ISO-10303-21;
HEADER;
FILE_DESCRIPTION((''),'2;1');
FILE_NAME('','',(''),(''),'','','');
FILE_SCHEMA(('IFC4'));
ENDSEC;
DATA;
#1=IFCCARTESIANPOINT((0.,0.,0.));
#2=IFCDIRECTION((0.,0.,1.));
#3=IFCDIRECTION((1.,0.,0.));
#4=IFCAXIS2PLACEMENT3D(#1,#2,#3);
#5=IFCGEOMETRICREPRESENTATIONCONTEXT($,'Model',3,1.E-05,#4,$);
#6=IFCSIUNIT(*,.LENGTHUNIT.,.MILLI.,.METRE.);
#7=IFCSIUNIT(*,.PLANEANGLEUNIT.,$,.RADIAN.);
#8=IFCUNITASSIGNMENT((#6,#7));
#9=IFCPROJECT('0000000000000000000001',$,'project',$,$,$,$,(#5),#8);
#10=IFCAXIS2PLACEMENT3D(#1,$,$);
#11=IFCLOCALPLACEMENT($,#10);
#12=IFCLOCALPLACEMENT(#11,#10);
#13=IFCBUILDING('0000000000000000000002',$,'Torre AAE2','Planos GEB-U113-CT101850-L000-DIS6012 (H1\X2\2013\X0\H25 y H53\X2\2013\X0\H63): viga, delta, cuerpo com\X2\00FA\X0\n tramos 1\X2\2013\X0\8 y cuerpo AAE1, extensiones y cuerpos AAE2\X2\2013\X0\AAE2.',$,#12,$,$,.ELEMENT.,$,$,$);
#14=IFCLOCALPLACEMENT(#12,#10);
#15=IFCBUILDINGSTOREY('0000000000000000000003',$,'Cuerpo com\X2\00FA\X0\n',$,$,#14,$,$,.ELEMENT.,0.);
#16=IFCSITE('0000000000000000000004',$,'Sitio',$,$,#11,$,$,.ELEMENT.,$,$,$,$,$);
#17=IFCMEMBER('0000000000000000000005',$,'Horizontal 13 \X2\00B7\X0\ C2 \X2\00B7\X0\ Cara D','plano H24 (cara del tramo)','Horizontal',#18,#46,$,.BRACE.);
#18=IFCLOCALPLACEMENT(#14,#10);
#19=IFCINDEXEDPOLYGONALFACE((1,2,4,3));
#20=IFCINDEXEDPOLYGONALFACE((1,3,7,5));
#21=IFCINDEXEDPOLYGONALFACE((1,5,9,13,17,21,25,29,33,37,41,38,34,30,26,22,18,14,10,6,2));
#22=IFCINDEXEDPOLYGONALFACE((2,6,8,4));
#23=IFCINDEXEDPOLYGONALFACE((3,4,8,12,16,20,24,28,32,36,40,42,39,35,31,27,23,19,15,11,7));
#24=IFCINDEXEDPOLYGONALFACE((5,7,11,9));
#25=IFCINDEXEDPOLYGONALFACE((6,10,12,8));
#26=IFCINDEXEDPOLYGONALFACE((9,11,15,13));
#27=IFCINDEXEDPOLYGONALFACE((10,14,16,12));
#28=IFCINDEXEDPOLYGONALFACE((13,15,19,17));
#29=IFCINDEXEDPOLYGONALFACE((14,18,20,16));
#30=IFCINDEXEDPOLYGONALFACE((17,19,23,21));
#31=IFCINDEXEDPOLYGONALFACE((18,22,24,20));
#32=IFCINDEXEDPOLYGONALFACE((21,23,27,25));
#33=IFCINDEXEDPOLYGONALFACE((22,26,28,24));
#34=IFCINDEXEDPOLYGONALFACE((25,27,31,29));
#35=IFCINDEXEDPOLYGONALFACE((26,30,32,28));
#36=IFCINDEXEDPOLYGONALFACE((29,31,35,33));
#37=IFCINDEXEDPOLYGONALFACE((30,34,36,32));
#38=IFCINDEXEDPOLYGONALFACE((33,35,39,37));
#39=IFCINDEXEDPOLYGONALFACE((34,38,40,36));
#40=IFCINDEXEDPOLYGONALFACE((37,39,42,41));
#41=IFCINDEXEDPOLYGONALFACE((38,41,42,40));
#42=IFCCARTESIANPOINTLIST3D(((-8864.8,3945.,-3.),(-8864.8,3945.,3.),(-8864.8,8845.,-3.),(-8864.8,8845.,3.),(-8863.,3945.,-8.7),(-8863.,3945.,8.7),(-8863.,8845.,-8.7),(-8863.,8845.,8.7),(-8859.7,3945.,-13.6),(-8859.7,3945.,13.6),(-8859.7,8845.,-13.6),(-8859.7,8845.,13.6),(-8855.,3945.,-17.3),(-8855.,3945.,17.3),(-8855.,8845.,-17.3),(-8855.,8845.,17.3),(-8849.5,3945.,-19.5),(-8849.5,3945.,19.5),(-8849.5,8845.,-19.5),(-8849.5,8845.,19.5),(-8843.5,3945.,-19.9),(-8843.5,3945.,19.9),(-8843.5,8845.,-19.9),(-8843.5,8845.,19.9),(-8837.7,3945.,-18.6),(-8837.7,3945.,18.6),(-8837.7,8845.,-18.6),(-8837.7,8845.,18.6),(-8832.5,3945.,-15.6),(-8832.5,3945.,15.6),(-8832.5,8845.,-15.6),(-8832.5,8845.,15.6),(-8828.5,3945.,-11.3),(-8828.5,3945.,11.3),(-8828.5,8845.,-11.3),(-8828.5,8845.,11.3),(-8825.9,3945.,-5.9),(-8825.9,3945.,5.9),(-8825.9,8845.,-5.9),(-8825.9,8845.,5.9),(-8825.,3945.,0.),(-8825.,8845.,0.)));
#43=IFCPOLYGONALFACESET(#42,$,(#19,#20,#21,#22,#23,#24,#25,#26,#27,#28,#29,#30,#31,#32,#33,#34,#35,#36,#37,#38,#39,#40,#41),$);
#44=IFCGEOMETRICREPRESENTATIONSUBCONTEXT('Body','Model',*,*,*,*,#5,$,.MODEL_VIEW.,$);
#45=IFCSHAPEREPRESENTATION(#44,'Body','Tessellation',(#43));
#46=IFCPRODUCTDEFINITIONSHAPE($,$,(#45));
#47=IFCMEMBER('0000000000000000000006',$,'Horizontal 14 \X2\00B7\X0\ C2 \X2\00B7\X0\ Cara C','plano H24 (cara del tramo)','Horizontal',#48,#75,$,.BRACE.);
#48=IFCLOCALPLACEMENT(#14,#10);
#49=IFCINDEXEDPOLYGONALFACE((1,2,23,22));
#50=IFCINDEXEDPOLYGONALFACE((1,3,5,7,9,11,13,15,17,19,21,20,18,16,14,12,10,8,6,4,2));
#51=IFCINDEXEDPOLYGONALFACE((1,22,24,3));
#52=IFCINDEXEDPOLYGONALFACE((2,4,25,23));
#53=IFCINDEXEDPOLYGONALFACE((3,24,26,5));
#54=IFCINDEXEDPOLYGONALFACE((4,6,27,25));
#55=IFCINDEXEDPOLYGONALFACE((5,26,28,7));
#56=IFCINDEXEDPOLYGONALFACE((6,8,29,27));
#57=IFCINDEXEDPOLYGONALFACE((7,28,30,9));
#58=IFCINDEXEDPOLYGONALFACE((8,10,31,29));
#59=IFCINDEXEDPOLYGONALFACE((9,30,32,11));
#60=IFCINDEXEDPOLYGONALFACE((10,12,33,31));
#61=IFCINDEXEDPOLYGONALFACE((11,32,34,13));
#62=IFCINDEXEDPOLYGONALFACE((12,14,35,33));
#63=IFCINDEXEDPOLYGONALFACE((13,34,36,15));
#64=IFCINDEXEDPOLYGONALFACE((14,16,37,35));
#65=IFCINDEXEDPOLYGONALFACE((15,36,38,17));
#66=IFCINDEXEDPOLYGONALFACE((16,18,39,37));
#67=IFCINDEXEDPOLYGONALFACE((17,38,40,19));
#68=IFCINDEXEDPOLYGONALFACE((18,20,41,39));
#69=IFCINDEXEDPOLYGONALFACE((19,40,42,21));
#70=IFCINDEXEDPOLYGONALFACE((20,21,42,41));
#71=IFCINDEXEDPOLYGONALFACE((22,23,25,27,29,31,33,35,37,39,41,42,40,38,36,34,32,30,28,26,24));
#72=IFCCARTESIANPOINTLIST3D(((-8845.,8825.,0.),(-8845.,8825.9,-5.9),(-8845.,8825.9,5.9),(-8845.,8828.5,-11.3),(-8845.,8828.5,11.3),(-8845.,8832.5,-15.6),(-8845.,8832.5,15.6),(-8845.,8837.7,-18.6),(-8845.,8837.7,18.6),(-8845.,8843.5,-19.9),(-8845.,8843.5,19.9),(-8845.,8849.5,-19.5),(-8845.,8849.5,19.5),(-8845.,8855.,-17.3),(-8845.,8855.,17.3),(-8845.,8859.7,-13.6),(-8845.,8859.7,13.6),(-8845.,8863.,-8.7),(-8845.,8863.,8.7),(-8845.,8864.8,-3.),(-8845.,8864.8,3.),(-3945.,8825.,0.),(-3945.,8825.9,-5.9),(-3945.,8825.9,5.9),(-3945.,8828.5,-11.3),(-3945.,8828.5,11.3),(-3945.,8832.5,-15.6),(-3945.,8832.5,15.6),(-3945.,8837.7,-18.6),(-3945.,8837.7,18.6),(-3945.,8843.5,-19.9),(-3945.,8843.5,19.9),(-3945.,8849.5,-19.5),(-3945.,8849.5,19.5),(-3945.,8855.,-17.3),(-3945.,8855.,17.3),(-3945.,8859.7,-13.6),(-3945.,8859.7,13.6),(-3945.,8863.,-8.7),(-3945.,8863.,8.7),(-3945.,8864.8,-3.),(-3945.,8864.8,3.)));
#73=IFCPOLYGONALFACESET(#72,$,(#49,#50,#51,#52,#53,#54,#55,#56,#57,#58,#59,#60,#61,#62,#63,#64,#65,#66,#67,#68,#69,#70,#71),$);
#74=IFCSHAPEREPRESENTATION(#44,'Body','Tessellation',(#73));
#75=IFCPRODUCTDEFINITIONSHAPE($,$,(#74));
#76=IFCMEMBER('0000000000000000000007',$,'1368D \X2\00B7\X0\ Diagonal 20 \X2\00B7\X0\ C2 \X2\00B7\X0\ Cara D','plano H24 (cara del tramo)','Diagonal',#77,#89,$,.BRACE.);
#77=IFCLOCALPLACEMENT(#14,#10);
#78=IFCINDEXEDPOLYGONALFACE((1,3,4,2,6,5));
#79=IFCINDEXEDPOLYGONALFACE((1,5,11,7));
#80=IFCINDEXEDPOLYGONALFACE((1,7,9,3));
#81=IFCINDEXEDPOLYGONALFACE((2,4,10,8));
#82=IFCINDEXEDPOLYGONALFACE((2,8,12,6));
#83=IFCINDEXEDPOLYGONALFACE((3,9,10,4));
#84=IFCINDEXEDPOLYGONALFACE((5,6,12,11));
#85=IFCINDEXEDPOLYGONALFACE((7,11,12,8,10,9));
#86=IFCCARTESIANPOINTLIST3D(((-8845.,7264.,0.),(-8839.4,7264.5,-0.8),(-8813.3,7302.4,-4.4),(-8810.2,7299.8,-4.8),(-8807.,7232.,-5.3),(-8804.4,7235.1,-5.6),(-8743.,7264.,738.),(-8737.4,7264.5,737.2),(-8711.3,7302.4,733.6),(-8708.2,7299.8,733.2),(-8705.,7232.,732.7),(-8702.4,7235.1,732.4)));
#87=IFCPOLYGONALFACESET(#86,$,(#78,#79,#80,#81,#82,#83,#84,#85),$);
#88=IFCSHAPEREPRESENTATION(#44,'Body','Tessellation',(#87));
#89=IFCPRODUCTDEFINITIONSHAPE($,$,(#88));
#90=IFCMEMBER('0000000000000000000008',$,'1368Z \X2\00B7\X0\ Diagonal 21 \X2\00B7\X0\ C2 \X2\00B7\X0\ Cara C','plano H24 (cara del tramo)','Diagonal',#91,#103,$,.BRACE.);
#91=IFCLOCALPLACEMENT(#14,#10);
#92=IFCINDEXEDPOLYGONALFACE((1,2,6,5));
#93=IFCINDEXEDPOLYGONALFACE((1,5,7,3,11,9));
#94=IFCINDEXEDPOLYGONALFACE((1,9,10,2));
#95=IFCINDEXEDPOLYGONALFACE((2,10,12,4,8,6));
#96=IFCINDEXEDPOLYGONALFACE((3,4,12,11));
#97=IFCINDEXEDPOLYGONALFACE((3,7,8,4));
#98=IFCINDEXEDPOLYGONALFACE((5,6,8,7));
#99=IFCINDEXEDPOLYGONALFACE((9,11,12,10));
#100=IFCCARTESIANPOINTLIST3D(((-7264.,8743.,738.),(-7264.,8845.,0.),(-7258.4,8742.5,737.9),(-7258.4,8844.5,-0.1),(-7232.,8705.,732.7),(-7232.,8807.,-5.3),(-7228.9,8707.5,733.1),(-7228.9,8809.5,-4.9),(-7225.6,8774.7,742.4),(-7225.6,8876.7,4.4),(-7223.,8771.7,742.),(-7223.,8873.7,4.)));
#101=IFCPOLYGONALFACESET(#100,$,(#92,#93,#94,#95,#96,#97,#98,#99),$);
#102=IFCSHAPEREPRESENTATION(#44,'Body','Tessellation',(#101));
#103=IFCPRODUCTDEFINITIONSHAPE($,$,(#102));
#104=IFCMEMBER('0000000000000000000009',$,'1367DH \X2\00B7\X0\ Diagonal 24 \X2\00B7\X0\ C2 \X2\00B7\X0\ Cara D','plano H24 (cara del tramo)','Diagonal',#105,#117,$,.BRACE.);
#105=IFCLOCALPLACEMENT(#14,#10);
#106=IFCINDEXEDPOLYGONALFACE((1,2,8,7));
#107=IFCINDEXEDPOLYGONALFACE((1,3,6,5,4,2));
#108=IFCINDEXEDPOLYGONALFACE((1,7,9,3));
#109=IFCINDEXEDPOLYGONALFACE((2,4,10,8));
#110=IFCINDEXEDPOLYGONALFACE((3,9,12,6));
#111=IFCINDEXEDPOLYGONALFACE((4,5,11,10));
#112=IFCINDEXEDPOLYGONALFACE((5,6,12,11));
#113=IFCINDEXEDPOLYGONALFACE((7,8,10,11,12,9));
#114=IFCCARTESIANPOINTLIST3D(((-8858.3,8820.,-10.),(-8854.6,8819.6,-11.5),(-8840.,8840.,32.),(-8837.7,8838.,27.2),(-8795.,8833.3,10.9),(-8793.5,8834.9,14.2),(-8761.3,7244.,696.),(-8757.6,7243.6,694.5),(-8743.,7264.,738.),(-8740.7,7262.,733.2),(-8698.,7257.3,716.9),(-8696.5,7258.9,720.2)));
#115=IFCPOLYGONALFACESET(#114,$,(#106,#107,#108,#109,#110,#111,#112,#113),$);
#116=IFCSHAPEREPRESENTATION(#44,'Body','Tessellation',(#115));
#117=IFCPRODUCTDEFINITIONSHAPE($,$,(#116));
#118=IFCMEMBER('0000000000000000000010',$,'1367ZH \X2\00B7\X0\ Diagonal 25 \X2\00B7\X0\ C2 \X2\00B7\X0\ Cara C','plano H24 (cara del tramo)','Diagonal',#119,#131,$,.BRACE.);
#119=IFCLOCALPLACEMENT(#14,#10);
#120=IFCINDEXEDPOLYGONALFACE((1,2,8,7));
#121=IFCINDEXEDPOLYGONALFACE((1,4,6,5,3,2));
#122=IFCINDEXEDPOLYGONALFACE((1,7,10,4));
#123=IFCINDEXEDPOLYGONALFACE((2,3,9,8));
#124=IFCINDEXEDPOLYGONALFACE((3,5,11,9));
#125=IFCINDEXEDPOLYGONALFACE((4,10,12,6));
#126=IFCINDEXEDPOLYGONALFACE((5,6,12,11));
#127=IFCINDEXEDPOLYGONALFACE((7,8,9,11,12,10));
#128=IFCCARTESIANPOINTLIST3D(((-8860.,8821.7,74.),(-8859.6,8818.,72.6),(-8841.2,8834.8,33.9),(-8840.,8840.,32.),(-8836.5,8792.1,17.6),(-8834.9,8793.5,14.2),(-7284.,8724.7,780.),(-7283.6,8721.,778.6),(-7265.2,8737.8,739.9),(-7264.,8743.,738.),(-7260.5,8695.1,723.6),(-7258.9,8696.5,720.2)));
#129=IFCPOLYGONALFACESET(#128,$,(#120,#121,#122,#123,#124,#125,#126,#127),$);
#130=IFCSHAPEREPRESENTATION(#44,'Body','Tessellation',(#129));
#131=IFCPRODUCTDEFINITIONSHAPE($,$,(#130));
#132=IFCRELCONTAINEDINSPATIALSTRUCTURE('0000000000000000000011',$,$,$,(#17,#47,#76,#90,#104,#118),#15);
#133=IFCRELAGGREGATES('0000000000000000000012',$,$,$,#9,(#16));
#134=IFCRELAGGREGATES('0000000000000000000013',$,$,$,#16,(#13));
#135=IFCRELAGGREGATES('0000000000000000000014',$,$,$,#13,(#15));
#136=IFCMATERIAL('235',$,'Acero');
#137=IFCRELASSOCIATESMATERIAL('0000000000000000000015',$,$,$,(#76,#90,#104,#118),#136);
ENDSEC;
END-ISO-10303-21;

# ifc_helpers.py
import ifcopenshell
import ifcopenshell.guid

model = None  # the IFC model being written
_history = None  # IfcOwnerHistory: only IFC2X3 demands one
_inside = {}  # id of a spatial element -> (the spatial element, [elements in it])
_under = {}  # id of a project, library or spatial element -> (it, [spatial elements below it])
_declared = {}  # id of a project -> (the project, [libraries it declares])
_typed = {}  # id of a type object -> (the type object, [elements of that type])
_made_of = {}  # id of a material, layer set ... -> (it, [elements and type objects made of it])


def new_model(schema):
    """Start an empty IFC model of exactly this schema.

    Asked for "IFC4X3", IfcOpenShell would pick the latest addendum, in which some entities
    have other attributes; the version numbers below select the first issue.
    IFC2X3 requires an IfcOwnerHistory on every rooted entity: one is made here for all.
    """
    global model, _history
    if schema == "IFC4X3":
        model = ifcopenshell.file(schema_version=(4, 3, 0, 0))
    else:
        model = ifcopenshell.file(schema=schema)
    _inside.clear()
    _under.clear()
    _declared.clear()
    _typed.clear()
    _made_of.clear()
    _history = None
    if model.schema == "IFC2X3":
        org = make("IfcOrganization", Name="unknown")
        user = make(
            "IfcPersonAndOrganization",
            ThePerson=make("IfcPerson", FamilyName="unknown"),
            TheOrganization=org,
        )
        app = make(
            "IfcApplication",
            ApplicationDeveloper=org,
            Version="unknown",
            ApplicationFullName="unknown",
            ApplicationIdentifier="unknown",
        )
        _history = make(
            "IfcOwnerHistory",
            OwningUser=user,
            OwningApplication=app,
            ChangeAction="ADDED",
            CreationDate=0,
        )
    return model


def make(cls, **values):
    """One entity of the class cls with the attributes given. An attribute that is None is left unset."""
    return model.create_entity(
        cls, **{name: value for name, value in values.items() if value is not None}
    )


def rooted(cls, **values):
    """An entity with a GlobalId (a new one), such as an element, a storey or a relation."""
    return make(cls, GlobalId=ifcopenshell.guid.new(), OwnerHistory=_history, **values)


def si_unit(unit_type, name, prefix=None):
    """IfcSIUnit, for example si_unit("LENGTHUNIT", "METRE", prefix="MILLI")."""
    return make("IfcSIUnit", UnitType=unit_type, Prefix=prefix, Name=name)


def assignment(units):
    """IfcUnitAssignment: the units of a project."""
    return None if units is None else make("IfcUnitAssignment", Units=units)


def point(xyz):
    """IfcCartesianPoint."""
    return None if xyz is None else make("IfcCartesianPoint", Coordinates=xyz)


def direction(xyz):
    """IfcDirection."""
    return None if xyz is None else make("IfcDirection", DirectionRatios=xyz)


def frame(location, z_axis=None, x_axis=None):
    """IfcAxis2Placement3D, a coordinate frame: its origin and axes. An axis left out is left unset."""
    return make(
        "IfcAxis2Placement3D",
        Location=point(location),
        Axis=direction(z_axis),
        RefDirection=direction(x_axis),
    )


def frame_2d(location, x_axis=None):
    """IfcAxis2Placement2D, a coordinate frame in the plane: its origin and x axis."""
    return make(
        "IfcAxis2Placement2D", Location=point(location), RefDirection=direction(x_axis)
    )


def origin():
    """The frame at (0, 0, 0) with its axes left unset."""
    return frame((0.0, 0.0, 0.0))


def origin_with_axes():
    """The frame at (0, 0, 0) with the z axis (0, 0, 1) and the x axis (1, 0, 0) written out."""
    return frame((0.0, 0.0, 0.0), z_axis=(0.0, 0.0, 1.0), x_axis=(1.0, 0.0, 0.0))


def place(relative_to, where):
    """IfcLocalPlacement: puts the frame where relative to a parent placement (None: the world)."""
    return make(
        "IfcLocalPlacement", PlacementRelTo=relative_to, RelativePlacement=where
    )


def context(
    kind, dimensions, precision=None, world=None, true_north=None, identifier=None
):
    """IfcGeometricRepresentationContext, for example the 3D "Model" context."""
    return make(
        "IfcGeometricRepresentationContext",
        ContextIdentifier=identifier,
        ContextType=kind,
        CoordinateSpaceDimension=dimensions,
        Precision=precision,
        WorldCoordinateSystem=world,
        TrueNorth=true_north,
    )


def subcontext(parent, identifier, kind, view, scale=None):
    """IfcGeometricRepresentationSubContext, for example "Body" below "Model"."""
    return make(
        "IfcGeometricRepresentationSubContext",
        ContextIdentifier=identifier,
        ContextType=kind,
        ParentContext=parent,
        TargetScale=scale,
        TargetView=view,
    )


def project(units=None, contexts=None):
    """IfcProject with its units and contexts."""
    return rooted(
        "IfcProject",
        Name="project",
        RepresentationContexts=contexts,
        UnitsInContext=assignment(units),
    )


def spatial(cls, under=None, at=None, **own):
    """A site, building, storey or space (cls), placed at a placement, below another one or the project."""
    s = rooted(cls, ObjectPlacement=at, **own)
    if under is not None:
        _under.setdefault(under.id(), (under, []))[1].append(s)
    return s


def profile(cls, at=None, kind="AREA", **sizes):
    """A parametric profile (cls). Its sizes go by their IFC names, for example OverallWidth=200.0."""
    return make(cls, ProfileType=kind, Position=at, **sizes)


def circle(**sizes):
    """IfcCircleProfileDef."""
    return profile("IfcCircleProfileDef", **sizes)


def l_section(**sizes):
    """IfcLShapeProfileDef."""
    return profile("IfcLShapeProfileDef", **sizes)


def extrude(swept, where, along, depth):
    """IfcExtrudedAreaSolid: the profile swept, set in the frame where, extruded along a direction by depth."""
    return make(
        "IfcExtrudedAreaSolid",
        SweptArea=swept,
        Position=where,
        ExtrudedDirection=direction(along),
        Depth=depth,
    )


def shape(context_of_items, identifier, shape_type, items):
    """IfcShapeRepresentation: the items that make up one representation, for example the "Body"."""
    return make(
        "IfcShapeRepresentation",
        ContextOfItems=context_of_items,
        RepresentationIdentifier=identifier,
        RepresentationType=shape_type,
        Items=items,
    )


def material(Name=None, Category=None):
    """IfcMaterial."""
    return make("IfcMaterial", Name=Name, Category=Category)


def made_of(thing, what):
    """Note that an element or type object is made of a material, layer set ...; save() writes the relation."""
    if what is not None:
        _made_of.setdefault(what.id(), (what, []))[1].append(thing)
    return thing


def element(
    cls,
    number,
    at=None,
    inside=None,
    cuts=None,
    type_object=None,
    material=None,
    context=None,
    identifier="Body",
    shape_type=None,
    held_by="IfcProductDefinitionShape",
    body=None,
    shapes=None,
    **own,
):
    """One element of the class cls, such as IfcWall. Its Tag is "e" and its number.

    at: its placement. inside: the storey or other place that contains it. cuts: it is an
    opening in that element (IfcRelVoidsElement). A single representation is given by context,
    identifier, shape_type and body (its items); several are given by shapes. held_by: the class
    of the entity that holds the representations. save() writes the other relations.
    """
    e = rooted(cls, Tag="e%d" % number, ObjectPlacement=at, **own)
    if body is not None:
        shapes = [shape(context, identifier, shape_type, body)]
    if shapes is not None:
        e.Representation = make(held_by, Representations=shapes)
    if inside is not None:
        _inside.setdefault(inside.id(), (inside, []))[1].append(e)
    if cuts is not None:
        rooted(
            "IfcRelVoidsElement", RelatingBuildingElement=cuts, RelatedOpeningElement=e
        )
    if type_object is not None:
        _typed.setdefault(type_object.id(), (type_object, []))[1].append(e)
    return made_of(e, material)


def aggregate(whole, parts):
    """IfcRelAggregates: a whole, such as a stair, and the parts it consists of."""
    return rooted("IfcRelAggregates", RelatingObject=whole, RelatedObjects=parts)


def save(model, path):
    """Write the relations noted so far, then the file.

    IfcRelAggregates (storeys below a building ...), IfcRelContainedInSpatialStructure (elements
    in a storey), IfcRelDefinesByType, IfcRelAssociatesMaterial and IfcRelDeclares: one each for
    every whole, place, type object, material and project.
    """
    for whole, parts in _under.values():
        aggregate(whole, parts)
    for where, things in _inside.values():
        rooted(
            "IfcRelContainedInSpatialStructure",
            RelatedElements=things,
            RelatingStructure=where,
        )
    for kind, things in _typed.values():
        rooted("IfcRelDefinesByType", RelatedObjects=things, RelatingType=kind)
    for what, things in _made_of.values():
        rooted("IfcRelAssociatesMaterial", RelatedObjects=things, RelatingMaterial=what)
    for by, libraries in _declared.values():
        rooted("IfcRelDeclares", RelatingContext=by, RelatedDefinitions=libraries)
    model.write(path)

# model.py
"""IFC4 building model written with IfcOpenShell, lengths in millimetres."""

from ifc_helpers import new_model, si_unit, frame, frame_2d, origin, origin_with_axes, place, context, subcontext, project, spatial, circle, l_section, extrude, material, element, save


model = new_model("IFC4")

# Units and contexts
model_context = context("Model", 3, precision=1e-05, world=origin_with_axes())
body_context = subcontext(model_context, "Body", "Model", "MODEL_VIEW")
ifc_project = project(units=[si_unit("LENGTHUNIT", "METRE", prefix="MILLI"), si_unit("PLANEANGLEUNIT", "RADIAN")], contexts=[model_context])

# Site, building, storey
site_placement = place(None, origin())
site = spatial("IfcSite", under=ifc_project, at=site_placement, Name="Sitio", CompositionType="ELEMENT")
building_placement = place(site_placement, origin())
building = spatial("IfcBuilding", under=site, at=building_placement, Name="Torre AAE2", Description="Planos GEB-U113-CT101850-L000-DIS6012 (H1–H25 y H53–H63): viga, delta, cuerpo común tramos 1–8 y cuerpo AAE1, extensiones y cuerpos AAE2–AAE2.", CompositionType="ELEMENT")
storey_placement = place(building_placement, origin())
storey = spatial("IfcBuildingStorey", under=building, at=storey_placement, Name="Cuerpo común", CompositionType="ELEMENT", Elevation=0.0)

# Members
ifc_material_1 = material(Name="235", Category="Acero")
for number, where, z_axis, x_axis, name in (
    (1, (-8845.0, 8845.0, 0.0), (0.0, -1.0, 0.0), (1.0, 0.0, 0.0), "Horizontal 13 · C2 · Cara D"),
    (2, (-8845.0, 8845.0, 0.0), (1.0, 0.0, 0.0), (0.0, -1.0, 0.0), "Horizontal 14 · C2 · Cara C"),
):
    element("IfcMember", number, at=place(storey_placement, frame(where, z_axis=z_axis, x_axis=x_axis)), inside=storey, Name=name, Description="plano H24 (cara del tramo)", ObjectType="Horizontal", PredefinedType="BRACE", context=body_context, shape_type="SweptSolid", body=[
        extrude(circle(Radius=20.0), None, (0.0, 0.0, 1.0), 4900.0),
    ])
for number, where, z_axis, x_axis, name in (
    (3, (-8845.0, 7264.0, 0.0), (0.13691, 0.0, 0.990584), (0.760787, -0.640428, -0.105149), "1368D · Diagonal 20 · C2 · Cara D"),
    (4, (-7264.0, 8845.0, 0.0), (0.0, -0.13691, 0.990584), (0.640428, -0.760787, -0.105149), "1368Z · Diagonal 21 · C2 · Cara C"),
):
    element("IfcMember", number, at=place(storey_placement, frame(where, z_axis=z_axis, x_axis=x_axis)), inside=storey, material=ifc_material_1, Name=name, Description="plano H24 (cara del tramo)", ObjectType="Diagonal", PredefinedType="BRACE", context=body_context, shape_type="SweptSolid", body=[
        extrude(l_section(Depth=50.0, Width=50.0, Thickness=4.0, at=frame_2d((25.0, 25.0))), None, (0.0, 0.0, 1.0), 745.0),
    ])
for number, where, z_axis, x_axis, name in (
    (5, (-8743.0, 7264.0, 738.0), (-0.056081, 0.911177, -0.40818), (0.929083, -0.102073, -0.355507), "1367DH · Diagonal 24 · C2 · Cara D"),
    (6, (-7264.0, 8743.0, 738.0), (-0.911177, 0.056081, -0.40818), (0.102073, -0.929083, -0.355507), "1367ZH · Diagonal 25 · C2 · Cara C"),
):
    element("IfcMember", number, at=place(storey_placement, frame(where, z_axis=z_axis, x_axis=x_axis)), inside=storey, material=ifc_material_1, Name=name, Description="plano H24 (cara del tramo)", ObjectType="Diagonal", PredefinedType="BRACE", context=body_context, shape_type="SweptSolid", body=[
        extrude(l_section(Depth=50.0, Width=50.0, Thickness=4.0, at=frame_2d((25.0, 25.0))), None, (0.0, 0.0, 1.0), 1729.6),
    ])

save(model, "model.ifc")
